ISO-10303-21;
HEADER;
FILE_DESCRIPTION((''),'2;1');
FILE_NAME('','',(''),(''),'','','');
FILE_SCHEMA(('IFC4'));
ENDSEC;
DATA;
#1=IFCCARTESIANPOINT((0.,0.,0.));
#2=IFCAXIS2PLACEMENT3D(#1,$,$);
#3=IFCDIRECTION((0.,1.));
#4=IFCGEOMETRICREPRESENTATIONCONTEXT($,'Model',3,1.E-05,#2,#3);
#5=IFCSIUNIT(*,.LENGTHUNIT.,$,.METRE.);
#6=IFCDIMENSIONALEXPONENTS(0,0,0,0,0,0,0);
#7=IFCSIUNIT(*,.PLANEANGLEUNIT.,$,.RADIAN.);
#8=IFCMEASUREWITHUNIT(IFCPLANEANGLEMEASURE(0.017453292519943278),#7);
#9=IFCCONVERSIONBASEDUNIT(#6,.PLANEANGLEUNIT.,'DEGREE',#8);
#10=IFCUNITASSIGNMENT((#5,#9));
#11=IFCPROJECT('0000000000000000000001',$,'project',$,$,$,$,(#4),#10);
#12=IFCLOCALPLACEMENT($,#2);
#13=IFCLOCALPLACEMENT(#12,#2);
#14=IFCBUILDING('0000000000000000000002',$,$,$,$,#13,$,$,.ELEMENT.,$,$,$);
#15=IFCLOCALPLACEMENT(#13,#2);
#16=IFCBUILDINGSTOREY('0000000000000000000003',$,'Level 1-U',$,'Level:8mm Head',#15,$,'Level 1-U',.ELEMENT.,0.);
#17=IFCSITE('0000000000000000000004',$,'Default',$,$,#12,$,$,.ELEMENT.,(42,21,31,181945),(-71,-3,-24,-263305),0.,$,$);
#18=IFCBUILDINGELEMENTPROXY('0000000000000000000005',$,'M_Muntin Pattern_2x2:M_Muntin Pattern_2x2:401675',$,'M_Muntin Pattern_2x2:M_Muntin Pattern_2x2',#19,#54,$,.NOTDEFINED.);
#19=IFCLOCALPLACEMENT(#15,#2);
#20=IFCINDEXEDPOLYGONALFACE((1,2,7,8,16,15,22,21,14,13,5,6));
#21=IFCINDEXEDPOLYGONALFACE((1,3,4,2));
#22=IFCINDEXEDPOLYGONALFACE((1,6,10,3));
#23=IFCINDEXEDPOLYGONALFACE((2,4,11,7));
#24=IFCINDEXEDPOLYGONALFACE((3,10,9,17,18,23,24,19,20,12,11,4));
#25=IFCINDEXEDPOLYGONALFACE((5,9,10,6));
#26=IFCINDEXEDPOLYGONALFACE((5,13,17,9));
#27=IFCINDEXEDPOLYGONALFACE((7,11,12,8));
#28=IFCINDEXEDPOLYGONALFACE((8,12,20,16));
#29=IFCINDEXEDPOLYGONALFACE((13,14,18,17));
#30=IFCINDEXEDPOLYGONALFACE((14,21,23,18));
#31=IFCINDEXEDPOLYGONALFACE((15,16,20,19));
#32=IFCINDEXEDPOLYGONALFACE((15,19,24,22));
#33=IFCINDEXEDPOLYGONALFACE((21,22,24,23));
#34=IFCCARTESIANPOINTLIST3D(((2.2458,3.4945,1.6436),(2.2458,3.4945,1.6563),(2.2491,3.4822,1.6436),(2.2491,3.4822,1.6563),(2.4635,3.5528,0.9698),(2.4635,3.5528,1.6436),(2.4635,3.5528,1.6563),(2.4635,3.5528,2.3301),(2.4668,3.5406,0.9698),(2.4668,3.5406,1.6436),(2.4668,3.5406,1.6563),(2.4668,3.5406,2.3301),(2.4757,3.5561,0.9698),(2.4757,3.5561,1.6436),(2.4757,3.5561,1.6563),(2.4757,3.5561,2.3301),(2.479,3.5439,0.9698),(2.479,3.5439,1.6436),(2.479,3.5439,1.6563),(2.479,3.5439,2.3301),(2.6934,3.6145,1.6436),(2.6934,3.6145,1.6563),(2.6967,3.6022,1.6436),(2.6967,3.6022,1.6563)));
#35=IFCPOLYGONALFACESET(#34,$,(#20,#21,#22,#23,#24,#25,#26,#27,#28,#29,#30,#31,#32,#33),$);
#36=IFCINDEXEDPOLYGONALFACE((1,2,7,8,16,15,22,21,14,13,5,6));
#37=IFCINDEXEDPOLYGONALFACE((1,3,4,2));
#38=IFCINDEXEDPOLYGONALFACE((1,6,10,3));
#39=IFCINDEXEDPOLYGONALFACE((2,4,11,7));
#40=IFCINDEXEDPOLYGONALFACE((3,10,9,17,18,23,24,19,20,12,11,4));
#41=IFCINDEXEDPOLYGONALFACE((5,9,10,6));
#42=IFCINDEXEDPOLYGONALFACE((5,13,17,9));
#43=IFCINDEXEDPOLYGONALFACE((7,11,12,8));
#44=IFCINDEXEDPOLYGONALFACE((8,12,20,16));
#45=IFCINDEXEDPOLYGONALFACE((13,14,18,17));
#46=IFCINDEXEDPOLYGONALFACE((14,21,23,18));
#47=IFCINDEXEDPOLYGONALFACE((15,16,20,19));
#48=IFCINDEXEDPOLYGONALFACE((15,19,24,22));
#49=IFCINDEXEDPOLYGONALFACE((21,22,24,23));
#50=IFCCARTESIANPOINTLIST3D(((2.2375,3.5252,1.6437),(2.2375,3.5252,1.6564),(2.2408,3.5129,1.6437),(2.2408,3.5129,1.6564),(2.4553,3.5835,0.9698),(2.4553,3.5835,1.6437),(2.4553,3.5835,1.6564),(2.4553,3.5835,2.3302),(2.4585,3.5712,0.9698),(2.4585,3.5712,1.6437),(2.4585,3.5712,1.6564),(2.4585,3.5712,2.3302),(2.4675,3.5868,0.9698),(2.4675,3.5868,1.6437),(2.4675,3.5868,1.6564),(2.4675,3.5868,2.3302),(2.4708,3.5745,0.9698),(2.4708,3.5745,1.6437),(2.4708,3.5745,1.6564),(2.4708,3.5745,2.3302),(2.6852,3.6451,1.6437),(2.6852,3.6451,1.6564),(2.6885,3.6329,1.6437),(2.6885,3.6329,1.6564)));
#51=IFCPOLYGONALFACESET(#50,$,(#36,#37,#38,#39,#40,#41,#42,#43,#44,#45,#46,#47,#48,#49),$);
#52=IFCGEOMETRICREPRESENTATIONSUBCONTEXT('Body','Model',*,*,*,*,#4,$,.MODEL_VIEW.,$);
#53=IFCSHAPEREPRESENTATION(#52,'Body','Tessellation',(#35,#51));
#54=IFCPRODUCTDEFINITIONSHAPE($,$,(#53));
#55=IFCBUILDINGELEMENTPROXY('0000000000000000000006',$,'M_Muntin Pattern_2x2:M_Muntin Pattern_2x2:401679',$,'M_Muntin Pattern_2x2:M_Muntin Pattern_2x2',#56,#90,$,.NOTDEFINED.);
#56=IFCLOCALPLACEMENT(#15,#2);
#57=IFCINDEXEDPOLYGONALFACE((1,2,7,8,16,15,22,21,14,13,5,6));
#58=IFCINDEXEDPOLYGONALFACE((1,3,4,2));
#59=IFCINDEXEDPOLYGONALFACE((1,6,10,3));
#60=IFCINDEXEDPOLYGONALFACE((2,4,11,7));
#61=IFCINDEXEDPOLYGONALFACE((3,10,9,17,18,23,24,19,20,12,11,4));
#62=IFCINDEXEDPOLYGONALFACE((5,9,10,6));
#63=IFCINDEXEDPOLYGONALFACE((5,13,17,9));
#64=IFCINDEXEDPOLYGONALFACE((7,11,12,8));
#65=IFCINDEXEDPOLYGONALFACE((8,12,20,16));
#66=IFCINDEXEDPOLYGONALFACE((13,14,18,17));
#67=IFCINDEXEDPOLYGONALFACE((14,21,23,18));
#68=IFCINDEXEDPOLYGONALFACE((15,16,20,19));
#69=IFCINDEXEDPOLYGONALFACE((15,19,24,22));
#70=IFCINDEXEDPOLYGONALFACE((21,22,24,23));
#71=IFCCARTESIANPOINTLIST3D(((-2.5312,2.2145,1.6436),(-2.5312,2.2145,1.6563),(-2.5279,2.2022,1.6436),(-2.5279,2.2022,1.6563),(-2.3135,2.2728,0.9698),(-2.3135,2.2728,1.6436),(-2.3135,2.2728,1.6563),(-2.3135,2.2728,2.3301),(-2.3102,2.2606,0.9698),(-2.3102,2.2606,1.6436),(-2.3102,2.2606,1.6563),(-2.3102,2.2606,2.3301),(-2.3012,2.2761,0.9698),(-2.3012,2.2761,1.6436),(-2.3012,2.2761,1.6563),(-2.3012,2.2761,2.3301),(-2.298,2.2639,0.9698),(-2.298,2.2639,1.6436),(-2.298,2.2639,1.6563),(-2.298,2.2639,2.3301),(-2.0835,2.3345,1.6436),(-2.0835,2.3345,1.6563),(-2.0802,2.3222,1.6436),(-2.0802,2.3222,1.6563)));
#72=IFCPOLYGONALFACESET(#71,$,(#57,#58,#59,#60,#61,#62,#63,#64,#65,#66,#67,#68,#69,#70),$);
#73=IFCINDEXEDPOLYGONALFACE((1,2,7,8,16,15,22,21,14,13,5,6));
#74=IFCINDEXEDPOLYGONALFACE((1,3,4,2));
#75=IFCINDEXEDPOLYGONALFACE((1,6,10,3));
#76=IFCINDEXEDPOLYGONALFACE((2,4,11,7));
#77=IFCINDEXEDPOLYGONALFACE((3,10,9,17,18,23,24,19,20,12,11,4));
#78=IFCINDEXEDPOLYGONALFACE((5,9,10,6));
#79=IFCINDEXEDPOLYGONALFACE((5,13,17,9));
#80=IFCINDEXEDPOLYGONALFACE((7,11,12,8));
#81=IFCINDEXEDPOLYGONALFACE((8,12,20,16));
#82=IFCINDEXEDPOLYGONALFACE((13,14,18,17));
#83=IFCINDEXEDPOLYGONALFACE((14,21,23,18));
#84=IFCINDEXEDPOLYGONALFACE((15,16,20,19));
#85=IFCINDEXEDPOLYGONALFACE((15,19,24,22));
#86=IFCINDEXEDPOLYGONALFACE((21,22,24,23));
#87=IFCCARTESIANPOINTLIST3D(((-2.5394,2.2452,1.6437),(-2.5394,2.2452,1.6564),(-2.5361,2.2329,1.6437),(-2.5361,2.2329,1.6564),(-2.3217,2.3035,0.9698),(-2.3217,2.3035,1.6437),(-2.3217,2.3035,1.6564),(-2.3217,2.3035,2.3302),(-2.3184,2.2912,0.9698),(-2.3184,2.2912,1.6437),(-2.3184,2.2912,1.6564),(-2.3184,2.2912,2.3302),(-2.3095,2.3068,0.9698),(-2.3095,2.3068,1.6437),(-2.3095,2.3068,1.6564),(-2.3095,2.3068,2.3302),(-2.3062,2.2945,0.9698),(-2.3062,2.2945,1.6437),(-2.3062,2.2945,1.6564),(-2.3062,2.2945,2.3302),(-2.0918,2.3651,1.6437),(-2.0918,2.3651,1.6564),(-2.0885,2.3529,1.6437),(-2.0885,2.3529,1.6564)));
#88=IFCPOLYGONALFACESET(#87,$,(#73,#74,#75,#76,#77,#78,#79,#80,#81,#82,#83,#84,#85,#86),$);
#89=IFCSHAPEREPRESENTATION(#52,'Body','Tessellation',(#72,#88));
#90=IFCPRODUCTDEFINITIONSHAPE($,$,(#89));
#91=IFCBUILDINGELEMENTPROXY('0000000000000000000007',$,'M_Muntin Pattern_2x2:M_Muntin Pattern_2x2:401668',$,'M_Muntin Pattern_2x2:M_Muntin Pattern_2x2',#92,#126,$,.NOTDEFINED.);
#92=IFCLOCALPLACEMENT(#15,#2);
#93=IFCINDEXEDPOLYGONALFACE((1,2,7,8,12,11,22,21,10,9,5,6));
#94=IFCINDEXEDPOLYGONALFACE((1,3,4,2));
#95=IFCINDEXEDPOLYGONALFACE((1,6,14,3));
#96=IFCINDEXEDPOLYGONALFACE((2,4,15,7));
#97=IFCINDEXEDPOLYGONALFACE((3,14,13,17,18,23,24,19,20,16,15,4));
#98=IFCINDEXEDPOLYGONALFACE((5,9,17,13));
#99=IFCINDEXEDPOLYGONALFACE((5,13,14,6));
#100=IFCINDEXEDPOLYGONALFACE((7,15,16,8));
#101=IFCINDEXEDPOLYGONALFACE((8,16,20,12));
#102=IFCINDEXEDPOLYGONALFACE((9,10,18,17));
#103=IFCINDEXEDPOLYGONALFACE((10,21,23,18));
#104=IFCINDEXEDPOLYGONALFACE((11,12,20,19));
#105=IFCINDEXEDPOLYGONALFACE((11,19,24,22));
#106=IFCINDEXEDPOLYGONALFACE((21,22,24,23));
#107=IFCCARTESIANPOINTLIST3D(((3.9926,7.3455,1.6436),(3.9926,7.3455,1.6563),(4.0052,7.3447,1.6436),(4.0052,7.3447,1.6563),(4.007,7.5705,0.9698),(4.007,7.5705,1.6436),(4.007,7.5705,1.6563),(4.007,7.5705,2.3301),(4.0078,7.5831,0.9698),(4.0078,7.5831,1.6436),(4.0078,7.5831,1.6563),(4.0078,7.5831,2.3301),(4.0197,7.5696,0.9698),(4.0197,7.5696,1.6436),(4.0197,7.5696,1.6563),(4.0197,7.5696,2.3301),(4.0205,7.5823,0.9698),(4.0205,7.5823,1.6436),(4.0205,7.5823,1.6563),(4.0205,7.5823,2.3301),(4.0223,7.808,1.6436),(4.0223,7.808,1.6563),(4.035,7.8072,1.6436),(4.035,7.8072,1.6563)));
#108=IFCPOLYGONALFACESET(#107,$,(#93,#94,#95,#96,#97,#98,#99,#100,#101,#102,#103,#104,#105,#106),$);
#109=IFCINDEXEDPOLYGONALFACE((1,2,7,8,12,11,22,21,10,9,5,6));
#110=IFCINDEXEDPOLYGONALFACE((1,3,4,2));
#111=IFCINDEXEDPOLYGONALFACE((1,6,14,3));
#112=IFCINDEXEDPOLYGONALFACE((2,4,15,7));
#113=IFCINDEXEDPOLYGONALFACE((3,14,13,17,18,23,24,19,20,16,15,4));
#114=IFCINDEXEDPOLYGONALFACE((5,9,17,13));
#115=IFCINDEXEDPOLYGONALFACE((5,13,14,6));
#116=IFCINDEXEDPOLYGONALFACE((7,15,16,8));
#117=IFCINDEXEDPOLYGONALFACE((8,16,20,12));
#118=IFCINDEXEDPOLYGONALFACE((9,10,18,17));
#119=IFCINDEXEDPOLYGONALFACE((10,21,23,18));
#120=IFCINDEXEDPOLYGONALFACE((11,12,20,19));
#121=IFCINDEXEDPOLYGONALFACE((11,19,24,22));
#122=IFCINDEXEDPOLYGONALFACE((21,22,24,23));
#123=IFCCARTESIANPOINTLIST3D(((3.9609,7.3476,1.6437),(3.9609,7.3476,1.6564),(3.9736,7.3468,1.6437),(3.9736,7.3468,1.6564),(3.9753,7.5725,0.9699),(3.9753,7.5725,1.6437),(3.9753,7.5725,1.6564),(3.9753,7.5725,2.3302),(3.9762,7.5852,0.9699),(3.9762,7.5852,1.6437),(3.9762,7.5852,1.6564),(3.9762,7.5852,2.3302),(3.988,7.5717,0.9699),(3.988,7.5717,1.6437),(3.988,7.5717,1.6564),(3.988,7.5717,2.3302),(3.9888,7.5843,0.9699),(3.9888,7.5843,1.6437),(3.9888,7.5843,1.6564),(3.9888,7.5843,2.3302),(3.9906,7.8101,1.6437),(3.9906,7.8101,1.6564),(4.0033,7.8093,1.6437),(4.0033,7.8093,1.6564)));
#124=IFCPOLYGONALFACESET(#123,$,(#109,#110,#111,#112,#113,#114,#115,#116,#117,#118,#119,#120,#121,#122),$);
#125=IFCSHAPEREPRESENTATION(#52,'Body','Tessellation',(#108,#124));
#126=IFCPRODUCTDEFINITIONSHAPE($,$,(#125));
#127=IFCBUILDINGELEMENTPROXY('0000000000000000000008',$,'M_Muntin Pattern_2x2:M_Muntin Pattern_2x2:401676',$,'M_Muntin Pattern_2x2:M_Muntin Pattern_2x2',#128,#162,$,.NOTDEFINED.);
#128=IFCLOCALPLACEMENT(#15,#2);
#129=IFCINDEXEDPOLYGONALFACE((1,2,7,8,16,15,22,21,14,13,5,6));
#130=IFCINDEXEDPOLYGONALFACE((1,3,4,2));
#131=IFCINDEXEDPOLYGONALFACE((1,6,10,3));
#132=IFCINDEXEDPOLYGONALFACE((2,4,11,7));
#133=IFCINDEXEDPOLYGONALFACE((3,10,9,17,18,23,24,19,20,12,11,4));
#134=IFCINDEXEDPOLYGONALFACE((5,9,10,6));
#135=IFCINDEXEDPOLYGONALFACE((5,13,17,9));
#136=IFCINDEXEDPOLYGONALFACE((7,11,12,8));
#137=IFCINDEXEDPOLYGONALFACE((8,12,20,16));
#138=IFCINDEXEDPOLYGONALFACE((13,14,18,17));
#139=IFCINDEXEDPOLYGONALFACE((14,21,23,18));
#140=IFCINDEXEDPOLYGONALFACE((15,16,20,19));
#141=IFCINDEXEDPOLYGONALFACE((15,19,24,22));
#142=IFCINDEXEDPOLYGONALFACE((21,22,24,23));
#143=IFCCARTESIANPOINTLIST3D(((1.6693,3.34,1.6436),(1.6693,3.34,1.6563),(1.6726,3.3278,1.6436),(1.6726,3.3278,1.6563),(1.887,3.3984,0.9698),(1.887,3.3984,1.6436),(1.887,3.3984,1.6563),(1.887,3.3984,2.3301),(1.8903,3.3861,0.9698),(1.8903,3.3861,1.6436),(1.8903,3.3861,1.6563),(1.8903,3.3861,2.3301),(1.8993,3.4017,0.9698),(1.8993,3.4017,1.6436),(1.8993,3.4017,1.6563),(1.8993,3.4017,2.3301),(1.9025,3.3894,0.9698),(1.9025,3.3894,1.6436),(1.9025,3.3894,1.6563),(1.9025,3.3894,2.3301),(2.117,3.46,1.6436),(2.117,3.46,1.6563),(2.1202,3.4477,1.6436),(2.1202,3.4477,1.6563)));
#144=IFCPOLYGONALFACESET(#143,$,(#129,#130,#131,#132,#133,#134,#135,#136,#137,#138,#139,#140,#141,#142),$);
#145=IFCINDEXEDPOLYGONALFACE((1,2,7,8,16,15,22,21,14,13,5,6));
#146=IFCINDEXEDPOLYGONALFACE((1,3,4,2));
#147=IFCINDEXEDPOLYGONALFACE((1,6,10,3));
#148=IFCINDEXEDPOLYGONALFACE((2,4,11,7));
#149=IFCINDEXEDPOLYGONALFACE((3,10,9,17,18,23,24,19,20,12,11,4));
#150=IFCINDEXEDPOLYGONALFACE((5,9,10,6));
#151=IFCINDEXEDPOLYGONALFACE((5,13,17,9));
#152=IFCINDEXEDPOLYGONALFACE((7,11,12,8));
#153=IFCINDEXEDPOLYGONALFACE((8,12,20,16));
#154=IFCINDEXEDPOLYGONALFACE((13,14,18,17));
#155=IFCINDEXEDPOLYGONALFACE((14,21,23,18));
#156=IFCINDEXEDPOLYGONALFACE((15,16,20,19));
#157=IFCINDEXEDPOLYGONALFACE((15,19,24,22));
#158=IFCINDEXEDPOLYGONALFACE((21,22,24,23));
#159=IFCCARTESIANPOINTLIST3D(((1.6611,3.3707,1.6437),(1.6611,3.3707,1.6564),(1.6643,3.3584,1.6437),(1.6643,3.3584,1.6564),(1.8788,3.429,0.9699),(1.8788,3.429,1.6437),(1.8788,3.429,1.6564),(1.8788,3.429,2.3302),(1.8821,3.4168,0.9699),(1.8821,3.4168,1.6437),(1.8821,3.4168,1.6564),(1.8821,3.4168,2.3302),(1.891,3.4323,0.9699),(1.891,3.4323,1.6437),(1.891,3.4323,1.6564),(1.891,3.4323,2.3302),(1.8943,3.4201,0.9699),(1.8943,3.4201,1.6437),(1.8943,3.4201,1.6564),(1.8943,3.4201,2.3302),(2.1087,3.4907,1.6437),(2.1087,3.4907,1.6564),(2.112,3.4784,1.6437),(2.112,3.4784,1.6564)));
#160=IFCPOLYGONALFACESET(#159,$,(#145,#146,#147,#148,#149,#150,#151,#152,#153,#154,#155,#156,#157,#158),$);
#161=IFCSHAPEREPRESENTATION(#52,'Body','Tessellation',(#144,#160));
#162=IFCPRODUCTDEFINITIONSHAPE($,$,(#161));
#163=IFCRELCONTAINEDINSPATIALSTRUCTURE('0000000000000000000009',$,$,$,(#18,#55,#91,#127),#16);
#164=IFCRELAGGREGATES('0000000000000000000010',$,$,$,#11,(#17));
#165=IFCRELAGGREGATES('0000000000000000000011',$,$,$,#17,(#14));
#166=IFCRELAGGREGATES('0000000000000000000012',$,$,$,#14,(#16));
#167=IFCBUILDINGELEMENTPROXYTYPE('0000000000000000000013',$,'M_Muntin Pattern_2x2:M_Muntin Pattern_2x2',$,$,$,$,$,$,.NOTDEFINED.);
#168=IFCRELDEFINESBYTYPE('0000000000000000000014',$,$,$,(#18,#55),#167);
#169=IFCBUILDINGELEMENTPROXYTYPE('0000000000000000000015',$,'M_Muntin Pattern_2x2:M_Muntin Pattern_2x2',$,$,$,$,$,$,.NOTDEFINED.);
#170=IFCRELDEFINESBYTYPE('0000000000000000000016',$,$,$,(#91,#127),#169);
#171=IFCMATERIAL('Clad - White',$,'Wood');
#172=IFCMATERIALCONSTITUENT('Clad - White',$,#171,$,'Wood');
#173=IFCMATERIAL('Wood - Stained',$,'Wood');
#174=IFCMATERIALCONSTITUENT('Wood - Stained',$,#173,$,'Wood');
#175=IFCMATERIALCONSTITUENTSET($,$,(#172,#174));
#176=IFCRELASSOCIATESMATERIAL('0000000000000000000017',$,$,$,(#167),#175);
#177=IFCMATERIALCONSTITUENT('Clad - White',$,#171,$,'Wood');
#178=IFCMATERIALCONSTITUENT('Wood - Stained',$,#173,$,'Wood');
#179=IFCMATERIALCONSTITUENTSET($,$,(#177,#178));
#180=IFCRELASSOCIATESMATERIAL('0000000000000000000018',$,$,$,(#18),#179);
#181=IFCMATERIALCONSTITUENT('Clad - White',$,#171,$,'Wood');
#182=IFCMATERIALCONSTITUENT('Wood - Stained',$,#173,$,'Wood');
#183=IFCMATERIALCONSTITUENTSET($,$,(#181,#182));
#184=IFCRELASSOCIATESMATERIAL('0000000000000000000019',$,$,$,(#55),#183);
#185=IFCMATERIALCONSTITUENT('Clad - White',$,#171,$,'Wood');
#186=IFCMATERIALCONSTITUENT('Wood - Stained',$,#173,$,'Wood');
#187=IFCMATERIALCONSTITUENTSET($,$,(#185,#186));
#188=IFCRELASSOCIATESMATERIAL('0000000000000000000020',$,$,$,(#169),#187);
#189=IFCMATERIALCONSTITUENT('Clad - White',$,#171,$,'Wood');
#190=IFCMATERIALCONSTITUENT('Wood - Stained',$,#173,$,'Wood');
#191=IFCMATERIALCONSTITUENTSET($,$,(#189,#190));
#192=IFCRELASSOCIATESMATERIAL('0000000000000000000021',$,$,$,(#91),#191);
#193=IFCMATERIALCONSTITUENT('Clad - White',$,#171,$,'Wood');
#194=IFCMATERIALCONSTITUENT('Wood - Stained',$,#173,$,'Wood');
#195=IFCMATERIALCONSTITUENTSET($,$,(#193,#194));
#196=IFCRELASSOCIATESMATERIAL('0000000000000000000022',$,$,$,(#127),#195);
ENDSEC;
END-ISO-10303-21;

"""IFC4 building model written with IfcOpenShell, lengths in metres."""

from ifc_helpers import new_model, entity, si_unit, converted_unit, direction, frame, origin, place, context, subcontext, project, spatial, polyline, outline, extrude, source, transform, mapped, material, constituent, constituent_set, type_object, type_shapes, element, save


model = new_model("IFC4")

# Units and contexts
model_context = context("Model", 3, precision=1e-05, world=origin(), true_north=direction((0.0, 1.0)))
body_context = subcontext(model_context, "Body", "Model", "MODEL_VIEW")
ifc_project = project(units=[si_unit("LENGTHUNIT", "METRE"), converted_unit("PLANEANGLEUNIT", "DEGREE", entity("IfcPlaneAngleMeasure", 0.017453292519943278), si_unit("PLANEANGLEUNIT", "RADIAN"), dimensions=[0, 0, 0, 0, 0, 0, 0])], contexts=[model_context])

# Site, building, storey
site_placement = place(None, origin())
site = spatial("IfcSite", under=ifc_project, at=site_placement, Name="Default", CompositionType="ELEMENT", RefLatitude=(42, 21, 31, 181945), RefLongitude=(-71, -3, -24, -263305), RefElevation=0.0)
building_placement = place(site_placement, origin())
building = spatial("IfcBuilding", under=site, at=building_placement, CompositionType="ELEMENT")
storey_placement = place(building_placement, origin())
storey = spatial("IfcBuildingStorey", under=building, at=storey_placement, Name="Level 1-U", ObjectType="Level:8mm Head", LongName="Level 1-U", CompositionType="ELEMENT", Elevation=0.0)

# Building element proxies
ifc_material_1 = material(Name="Clad - White", Category="Wood")
ifc_material_2 = material(Name="Wood - Stained", Category="Wood")
ifc_constituent_1 = constituent(ifc_material_1, Name="Clad - White", Category="Wood")
ifc_constituent_2 = constituent(ifc_material_2, Name="Wood - Stained", Category="Wood")
ifc_constituent_set_1 = constituent_set(constituents=[ifc_constituent_1, ifc_constituent_2])
building_element_proxy_type_1 = type_object("IfcBuildingElementProxyType", Name="M_Muntin Pattern_2x2:M_Muntin Pattern_2x2", PredefinedType="NOTDEFINED", material=ifc_constituent_set_1)
shared_shape_1 = source(origin(), body_context, "Body", "SweptSolid", [
    extrude(outline(polyline([(0.0064, -0.0064), (0.6801, -0.0064), (0.6801, 0.0063), (0.0064, 0.0063), (0.0064, 0.2317), (-0.0063, 0.2317), (-0.0063, 0.0063), (-0.6802, 0.0063), (-0.6802, -0.0064), (-0.0063, -0.0064), (-0.0063, -0.2317), (0.0064, -0.2317), (0.0064, -0.0064)])), frame((0.0, 0.0095, 0.6801), z_axis=(0.0, 1.0, 0.0), x_axis=(0.0, 0.0, 1.0)), (0.0, 0.0, 1.0), 0.0127),
    extrude(outline(polyline([(0.0064, -0.0064), (0.6802, -0.0064), (0.6802, 0.0063), (0.0064, 0.0063), (0.0064, 0.2317), (-0.0063, 0.2317), (-0.0063, 0.0063), (-0.6802, 0.0063), (-0.6802, -0.0064), (-0.0063, -0.0064), (-0.0063, -0.2317), (0.0064, -0.2317), (0.0064, -0.0064)])), frame((0.0, -0.0222, 0.6802), z_axis=(0.0, 1.0, 0.0), x_axis=(0.0, 0.0, 1.0)), (0.0, 0.0, 1.0), 0.0127),
])
type_shapes(building_element_proxy_type_1, [shared_shape_1])
ifc_constituent_3 = constituent(ifc_material_1, Name="Clad - White", Category="Wood")
ifc_constituent_4 = constituent(ifc_material_2, Name="Wood - Stained", Category="Wood")
ifc_constituent_set_2 = constituent_set(constituents=[ifc_constituent_3, ifc_constituent_4])
proxy_1_placement = place(storey_placement, frame((2.4671, 3.5637, 0.9698), z_axis=(0.0, 0.0, 1.0), x_axis=(-0.965926, -0.258819, 0.0)))
element("IfcBuildingElementProxy", 1, at=proxy_1_placement, inside=storey, type_object=building_element_proxy_type_1, material=ifc_constituent_set_2, Name="M_Muntin Pattern_2x2:M_Muntin Pattern_2x2:401675", ObjectType="M_Muntin Pattern_2x2:M_Muntin Pattern_2x2", PredefinedType="NOTDEFINED", context=body_context, shape_type="MappedRepresentation", body=[
    mapped(shared_shape_1, transform((0.0, 0.0, 0.0), scale=1.0)),
])
ifc_constituent_5 = constituent(ifc_material_1, Name="Clad - White", Category="Wood")
ifc_constituent_6 = constituent(ifc_material_2, Name="Wood - Stained", Category="Wood")
ifc_constituent_set_3 = constituent_set(constituents=[ifc_constituent_5, ifc_constituent_6])
proxy_2_placement = place(storey_placement, frame((-2.3098, 2.2837, 0.9698), z_axis=(0.0, 0.0, 1.0), x_axis=(-0.965926, -0.258819, 0.0)))
element("IfcBuildingElementProxy", 2, at=proxy_2_placement, inside=storey, type_object=building_element_proxy_type_1, material=ifc_constituent_set_3, Name="M_Muntin Pattern_2x2:M_Muntin Pattern_2x2:401679", ObjectType="M_Muntin Pattern_2x2:M_Muntin Pattern_2x2", PredefinedType="NOTDEFINED", context=body_context, shape_type="MappedRepresentation", body=[
    mapped(shared_shape_1, transform((0.0, 0.0, 0.0), scale=1.0)),
])
ifc_constituent_7 = constituent(ifc_material_1, Name="Clad - White", Category="Wood")
ifc_constituent_8 = constituent(ifc_material_2, Name="Wood - Stained", Category="Wood")
ifc_constituent_set_4 = constituent_set(constituents=[ifc_constituent_7, ifc_constituent_8])
ifc_constituent_9 = constituent(ifc_material_1, Name="Clad - White", Category="Wood")
ifc_constituent_10 = constituent(ifc_material_2, Name="Wood - Stained", Category="Wood")
ifc_constituent_set_5 = constituent_set(constituents=[ifc_constituent_9, ifc_constituent_10])
building_element_proxy_type_2 = type_object("IfcBuildingElementProxyType", Name="M_Muntin Pattern_2x2:M_Muntin Pattern_2x2", PredefinedType="NOTDEFINED", material=ifc_constituent_set_5)
shared_shape_2 = source(origin(), body_context, "Body", "SweptSolid", [
    extrude(outline(polyline([(0.0064, -0.0064), (0.6801, -0.0064), (0.6801, 0.0063), (0.0064, 0.0063), (0.0064, 0.2317), (-0.0063, 0.2317), (-0.0063, 0.0063), (-0.6802, 0.0063), (-0.6802, -0.0064), (-0.0063, -0.0064), (-0.0063, -0.2317), (0.0064, -0.2317), (0.0064, -0.0064)])), frame((0.0, -0.0222, 0.6801), z_axis=(0.0, 1.0, 0.0), x_axis=(0.0, 0.0, 1.0)), (0.0, 0.0, 1.0), 0.0127),
    extrude(outline(polyline([(0.0064, -0.0064), (0.6802, -0.0064), (0.6802, 0.0063), (0.0064, 0.0063), (0.0064, 0.2317), (-0.0063, 0.2317), (-0.0063, 0.0063), (-0.6802, 0.0063), (-0.6802, -0.0064), (-0.0063, -0.0064), (-0.0063, -0.2317), (0.0064, -0.2317), (0.0064, -0.0064)])), frame((0.0, 0.0095, 0.6802), z_axis=(0.0, 1.0, 0.0), x_axis=(0.0, 0.0, 1.0)), (0.0, 0.0, 1.0), 0.0127),
])
type_shapes(building_element_proxy_type_2, [shared_shape_2])
proxy_3_placement = place(storey_placement, frame((3.9979, 7.5774, 0.9699), z_axis=(0.0, 0.0, 1.0), x_axis=(0.064186, 0.997938, 0.0)))
element("IfcBuildingElementProxy", 3, at=proxy_3_placement, inside=storey, type_object=building_element_proxy_type_2, material=ifc_constituent_set_4, Name="M_Muntin Pattern_2x2:M_Muntin Pattern_2x2:401668", ObjectType="M_Muntin Pattern_2x2:M_Muntin Pattern_2x2", PredefinedType="NOTDEFINED", context=body_context, shape_type="MappedRepresentation", body=[
    mapped(shared_shape_2, transform((0.0, 0.0, 0.0), scale=1.0)),
])
ifc_constituent_11 = constituent(ifc_material_1, Name="Clad - White", Category="Wood")
ifc_constituent_12 = constituent(ifc_material_2, Name="Wood - Stained", Category="Wood")
ifc_constituent_set_6 = constituent_set(constituents=[ifc_constituent_11, ifc_constituent_12])
proxy_4_placement = place(storey_placement, frame((1.8907, 3.4092, 0.9699), z_axis=(0.0, 0.0, 1.0), x_axis=(0.965926, 0.258819, 0.0)))
element("IfcBuildingElementProxy", 4, at=proxy_4_placement, inside=storey, type_object=building_element_proxy_type_2, material=ifc_constituent_set_6, Name="M_Muntin Pattern_2x2:M_Muntin Pattern_2x2:401676", ObjectType="M_Muntin Pattern_2x2:M_Muntin Pattern_2x2", PredefinedType="NOTDEFINED", context=body_context, shape_type="MappedRepresentation", body=[
    mapped(shared_shape_2, transform((0.0, 0.0, 0.0), scale=1.0)),
])

save(model, "model.ifc")
